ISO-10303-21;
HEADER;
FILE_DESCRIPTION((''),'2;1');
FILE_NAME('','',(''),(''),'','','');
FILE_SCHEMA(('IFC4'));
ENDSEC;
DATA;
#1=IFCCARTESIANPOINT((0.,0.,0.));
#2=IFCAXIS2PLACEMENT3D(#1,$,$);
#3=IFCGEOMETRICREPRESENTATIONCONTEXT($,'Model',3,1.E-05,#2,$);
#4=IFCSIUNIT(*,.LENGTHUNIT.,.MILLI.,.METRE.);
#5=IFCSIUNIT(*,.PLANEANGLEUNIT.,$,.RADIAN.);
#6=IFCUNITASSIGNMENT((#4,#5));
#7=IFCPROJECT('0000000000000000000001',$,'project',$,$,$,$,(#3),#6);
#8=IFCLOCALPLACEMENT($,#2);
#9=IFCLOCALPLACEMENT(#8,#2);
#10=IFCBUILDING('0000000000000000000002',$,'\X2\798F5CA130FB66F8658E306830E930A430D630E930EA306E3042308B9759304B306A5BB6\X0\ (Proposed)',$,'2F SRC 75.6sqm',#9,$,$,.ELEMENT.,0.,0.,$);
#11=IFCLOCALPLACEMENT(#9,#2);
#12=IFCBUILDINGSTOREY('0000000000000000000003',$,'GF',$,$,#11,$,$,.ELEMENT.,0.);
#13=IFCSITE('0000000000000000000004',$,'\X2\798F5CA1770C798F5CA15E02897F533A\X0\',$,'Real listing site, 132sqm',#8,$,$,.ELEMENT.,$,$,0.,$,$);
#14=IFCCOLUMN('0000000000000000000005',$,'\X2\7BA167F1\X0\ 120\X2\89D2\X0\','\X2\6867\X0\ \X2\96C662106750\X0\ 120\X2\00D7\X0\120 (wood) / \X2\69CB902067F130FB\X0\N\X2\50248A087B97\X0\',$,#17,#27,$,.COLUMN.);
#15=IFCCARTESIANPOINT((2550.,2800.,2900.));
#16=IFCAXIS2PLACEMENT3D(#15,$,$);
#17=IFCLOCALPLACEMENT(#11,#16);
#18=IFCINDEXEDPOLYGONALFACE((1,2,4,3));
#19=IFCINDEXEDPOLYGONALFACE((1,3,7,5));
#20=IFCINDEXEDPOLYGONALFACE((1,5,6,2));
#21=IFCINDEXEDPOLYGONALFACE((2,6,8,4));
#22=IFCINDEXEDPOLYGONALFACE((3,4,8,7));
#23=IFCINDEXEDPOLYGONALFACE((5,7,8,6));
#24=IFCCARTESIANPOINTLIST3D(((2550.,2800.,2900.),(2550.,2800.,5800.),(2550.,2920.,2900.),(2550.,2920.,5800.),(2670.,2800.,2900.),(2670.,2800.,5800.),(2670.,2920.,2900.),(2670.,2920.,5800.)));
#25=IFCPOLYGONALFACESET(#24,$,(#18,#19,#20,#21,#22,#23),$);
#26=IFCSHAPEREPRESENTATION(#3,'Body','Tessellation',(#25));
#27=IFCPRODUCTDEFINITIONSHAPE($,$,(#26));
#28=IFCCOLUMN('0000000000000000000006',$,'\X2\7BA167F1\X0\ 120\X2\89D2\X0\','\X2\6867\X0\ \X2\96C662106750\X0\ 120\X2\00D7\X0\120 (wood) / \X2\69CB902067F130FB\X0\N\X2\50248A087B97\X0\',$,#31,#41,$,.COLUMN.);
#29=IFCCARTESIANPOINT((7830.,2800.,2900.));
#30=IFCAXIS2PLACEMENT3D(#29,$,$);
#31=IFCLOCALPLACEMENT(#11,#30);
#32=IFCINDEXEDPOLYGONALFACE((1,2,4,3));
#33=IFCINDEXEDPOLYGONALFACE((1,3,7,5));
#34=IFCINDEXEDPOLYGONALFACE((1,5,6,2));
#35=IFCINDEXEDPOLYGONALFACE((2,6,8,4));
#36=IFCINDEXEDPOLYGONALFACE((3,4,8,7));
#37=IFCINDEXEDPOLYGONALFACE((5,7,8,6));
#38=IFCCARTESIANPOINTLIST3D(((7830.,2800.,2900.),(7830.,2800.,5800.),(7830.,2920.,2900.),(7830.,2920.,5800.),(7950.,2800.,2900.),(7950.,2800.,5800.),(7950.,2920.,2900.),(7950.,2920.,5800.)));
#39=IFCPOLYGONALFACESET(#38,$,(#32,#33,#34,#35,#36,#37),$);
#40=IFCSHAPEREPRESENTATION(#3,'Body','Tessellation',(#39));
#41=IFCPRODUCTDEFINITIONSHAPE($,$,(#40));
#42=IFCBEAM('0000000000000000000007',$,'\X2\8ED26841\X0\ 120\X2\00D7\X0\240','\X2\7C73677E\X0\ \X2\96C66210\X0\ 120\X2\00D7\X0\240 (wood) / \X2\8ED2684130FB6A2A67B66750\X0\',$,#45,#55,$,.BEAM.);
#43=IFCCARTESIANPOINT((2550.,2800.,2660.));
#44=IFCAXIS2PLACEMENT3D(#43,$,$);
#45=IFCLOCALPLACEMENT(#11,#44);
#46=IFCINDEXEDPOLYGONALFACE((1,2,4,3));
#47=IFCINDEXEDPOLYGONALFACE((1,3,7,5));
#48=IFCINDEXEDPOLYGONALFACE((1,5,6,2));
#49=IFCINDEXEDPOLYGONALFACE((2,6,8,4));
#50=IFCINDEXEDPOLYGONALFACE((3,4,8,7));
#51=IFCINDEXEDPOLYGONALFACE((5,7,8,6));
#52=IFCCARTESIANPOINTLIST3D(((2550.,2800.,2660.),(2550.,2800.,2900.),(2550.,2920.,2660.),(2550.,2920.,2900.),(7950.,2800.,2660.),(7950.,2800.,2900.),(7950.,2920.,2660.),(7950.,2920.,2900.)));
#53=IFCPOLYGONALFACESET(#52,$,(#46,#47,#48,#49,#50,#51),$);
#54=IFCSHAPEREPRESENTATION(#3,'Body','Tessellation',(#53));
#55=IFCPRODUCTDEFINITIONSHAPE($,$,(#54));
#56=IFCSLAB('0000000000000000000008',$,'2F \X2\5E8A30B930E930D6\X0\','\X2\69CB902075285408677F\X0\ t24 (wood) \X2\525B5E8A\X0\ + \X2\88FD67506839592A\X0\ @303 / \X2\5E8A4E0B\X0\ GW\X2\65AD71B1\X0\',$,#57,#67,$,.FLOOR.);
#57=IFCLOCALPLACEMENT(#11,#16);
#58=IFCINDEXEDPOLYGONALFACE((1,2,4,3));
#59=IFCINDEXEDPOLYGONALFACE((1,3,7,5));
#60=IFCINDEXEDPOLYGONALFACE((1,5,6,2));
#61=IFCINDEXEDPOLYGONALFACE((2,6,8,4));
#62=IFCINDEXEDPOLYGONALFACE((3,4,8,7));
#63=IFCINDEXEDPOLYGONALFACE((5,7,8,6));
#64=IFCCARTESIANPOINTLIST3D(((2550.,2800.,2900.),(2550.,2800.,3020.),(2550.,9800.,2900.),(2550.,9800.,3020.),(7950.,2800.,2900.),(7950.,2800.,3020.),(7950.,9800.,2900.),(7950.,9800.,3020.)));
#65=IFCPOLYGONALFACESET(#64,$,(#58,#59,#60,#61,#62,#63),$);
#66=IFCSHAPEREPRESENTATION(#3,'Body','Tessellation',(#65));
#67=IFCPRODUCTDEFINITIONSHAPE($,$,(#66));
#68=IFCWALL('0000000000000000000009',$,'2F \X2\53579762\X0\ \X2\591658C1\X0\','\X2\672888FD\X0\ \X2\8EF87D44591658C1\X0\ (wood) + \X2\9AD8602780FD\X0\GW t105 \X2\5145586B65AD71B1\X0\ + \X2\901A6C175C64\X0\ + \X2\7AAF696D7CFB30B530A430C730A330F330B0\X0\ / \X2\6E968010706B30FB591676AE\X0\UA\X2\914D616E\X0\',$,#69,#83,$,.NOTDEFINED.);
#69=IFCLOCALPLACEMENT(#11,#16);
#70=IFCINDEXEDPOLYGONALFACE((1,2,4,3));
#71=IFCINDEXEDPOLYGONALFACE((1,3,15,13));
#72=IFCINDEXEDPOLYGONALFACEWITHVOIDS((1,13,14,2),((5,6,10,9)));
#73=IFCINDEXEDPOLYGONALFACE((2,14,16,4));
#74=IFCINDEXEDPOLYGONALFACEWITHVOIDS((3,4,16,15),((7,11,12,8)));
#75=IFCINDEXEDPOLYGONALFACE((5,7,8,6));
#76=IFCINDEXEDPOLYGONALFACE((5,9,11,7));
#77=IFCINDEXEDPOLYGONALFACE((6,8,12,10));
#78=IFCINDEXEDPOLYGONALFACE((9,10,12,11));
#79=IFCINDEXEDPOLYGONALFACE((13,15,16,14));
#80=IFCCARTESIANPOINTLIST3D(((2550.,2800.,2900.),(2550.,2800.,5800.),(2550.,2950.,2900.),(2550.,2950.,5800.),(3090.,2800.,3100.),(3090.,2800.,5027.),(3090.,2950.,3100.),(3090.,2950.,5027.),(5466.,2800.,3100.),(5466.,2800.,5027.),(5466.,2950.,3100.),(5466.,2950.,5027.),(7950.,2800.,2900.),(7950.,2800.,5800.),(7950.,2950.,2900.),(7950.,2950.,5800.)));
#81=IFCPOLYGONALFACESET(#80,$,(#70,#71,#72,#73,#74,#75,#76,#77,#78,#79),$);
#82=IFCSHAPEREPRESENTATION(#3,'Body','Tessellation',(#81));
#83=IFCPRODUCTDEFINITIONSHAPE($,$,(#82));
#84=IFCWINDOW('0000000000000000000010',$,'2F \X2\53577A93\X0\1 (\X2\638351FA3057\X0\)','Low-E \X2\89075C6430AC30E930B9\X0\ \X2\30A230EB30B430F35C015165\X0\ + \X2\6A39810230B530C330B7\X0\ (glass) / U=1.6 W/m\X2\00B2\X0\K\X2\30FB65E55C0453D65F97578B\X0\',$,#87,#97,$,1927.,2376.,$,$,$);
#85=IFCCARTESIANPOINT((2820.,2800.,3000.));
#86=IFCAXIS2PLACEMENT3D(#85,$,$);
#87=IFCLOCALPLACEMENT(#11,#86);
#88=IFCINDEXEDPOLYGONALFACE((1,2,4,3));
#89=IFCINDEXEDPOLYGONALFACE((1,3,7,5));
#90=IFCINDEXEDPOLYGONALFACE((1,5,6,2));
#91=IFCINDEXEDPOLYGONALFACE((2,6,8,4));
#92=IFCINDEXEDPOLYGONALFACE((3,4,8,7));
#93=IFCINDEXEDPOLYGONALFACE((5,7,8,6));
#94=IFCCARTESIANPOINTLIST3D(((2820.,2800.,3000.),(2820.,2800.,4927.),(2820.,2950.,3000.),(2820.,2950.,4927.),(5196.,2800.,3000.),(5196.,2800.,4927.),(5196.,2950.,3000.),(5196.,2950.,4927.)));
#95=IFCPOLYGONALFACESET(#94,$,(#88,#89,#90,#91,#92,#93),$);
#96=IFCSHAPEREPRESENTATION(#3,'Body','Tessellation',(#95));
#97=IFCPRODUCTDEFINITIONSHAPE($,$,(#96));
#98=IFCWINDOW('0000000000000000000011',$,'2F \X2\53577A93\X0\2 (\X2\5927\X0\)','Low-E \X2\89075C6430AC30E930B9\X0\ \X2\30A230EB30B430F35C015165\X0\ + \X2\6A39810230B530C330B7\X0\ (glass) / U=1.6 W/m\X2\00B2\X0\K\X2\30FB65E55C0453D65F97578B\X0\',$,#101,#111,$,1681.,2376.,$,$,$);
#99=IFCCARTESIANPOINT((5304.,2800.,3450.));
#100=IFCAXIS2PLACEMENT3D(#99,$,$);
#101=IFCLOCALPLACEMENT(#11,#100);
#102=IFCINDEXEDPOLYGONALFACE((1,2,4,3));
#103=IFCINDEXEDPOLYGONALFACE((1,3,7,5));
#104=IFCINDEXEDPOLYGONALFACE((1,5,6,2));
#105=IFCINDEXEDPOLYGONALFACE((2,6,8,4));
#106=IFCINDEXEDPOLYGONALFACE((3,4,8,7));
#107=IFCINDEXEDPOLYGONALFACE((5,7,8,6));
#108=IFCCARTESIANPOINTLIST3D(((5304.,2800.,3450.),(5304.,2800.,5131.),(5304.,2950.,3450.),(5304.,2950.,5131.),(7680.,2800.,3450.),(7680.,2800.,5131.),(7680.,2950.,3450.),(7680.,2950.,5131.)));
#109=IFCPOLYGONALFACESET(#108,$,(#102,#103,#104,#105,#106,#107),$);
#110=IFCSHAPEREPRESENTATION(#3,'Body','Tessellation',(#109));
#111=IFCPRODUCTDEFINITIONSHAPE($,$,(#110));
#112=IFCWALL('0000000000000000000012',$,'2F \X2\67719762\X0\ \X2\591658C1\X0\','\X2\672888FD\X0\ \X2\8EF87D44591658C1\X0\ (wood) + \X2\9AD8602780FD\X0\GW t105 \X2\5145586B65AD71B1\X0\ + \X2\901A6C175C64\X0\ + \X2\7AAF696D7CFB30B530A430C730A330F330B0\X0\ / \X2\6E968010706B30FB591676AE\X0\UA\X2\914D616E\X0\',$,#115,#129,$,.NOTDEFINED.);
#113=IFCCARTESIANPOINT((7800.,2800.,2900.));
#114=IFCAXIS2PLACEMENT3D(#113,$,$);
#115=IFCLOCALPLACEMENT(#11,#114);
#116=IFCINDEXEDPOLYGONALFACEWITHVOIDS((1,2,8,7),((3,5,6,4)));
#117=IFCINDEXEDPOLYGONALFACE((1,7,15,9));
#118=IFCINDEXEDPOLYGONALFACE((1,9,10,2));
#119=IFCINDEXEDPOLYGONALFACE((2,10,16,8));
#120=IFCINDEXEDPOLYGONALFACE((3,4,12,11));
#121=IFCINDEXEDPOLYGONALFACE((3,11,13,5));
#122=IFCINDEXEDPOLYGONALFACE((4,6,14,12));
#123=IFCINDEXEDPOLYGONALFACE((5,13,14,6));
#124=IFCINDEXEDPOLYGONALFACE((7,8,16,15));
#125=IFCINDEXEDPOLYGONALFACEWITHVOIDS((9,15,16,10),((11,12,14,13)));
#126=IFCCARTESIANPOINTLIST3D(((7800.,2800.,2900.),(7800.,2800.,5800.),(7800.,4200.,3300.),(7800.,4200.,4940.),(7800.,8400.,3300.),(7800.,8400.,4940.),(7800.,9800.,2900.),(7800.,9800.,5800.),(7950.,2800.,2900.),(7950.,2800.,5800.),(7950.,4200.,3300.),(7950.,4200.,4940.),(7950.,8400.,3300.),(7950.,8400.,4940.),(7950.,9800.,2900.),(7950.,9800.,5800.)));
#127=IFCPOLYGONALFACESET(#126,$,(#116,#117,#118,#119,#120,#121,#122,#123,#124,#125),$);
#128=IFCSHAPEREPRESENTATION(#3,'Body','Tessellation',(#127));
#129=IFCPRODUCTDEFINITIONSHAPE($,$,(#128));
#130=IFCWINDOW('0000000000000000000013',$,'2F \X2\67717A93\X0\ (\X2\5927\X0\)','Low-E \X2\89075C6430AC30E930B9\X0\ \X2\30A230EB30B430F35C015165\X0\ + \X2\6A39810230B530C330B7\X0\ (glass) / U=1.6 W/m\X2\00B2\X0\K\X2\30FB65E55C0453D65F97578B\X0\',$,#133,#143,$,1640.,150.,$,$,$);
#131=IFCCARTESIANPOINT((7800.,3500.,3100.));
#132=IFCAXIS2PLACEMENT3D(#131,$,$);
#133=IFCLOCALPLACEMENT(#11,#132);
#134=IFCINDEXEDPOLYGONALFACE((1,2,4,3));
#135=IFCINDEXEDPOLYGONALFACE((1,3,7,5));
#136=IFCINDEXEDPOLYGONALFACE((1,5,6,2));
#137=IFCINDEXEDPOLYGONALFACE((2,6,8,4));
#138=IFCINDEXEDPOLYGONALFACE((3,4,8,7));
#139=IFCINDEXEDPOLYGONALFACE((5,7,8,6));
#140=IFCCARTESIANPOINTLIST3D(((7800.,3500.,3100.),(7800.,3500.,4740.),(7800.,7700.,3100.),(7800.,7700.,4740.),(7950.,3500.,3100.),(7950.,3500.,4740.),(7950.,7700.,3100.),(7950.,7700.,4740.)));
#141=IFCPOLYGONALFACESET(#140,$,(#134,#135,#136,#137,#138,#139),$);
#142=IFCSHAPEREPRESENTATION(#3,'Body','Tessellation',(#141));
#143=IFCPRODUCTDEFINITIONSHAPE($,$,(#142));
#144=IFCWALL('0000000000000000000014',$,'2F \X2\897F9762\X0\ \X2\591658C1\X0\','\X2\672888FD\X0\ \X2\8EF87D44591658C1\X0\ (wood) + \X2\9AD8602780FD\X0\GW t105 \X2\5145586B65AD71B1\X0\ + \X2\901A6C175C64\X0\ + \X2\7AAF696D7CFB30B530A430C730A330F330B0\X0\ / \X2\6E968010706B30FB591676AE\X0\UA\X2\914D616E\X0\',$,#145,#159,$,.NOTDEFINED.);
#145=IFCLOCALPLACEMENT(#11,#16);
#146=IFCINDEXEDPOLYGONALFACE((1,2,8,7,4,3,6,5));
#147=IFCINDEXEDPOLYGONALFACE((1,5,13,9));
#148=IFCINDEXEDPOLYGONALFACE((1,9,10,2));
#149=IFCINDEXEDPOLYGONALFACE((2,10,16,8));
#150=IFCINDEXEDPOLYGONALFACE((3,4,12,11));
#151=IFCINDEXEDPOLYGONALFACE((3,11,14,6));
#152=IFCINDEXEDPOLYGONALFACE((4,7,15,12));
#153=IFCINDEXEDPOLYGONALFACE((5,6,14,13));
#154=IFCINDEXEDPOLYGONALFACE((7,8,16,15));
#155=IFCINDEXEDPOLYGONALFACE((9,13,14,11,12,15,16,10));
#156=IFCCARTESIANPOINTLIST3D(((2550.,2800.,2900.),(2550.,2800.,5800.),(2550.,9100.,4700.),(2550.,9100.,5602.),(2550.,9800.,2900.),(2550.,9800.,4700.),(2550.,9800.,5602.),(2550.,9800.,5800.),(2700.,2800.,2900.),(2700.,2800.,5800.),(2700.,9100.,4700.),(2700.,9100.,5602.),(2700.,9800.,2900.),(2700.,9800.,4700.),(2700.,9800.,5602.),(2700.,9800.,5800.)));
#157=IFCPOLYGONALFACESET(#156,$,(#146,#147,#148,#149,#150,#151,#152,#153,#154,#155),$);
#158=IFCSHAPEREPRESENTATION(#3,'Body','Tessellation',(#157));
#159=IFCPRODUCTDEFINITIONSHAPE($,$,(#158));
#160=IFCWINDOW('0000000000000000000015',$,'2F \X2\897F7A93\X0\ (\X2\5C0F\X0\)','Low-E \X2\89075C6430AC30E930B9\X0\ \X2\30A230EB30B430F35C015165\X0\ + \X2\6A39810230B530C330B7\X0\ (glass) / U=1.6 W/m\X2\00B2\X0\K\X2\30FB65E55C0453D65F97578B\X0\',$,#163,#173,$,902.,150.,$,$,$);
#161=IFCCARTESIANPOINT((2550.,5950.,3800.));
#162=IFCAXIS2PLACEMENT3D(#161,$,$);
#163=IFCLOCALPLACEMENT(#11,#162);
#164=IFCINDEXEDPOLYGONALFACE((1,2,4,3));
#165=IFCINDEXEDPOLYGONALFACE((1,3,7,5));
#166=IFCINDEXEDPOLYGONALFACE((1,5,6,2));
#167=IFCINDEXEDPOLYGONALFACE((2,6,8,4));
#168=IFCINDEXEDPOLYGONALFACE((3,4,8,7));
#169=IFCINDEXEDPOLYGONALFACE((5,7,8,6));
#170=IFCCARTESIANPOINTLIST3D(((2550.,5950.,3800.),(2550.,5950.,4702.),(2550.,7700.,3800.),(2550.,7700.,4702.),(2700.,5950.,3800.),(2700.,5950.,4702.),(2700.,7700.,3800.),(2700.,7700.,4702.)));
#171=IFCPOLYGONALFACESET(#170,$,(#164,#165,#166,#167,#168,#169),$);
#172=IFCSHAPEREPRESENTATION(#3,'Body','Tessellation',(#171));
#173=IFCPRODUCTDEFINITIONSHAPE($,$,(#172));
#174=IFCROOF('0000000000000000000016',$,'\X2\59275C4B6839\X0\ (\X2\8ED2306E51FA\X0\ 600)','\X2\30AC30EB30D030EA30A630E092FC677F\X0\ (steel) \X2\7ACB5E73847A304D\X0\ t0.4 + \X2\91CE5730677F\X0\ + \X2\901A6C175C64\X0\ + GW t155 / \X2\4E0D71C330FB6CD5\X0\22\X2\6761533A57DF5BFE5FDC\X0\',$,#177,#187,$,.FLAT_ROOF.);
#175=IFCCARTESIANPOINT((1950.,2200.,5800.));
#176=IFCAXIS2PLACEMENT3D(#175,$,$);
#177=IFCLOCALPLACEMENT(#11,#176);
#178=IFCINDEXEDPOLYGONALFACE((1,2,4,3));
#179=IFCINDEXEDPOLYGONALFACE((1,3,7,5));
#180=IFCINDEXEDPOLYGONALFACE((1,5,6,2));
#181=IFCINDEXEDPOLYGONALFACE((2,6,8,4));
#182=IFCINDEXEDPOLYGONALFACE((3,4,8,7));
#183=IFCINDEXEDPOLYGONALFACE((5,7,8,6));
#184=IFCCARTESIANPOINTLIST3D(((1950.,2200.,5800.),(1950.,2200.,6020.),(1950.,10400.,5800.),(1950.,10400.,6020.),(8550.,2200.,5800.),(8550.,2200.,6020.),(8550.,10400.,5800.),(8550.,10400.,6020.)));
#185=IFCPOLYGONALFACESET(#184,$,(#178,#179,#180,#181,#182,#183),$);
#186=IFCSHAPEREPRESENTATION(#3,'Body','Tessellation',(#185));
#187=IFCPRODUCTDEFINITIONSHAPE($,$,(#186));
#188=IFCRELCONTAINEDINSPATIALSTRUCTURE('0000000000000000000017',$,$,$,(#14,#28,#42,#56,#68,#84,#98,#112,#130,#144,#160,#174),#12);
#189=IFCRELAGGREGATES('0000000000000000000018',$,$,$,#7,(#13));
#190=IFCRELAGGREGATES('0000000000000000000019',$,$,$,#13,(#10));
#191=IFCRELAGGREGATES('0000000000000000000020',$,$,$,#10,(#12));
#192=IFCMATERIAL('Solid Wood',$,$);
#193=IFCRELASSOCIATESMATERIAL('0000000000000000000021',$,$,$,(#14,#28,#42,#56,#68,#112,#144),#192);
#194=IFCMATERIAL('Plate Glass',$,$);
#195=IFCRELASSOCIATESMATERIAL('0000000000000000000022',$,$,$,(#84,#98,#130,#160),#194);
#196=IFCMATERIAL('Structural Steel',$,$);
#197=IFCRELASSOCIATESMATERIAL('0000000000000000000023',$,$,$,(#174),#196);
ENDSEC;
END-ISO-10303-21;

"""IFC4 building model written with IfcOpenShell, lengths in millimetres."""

from ifc_helpers import new_model, si_unit, frame, frame_2d, origin, place, context, project, spatial, rectangle, extrude, material, element, fill, save


model = new_model("IFC4")

# Units and contexts
model_context = context("Model", 3, precision=1e-05, world=origin())
ifc_project = project(units=[si_unit("LENGTHUNIT", "METRE", prefix="MILLI"), si_unit("PLANEANGLEUNIT", "RADIAN")], contexts=[model_context])

# Site, building, storey
site_placement = place(None, origin())
site = spatial("IfcSite", under=ifc_project, at=site_placement, Name="福岡県福岡市西区", ObjectType="Real listing site, 132sqm", CompositionType="ELEMENT", RefElevation=0.0)
building_placement = place(site_placement, origin())
building = spatial("IfcBuilding", under=site, at=building_placement, Name="福岡・書斎とライブラリのある静かな家 (Proposed)", ObjectType="2F SRC 75.6sqm", CompositionType="ELEMENT", ElevationOfRefHeight=0.0, ElevationOfTerrain=0.0)
storey_placement = place(building_placement, origin())
storey = spatial("IfcBuildingStorey", under=building, at=storey_placement, Name="GF", CompositionType="ELEMENT", Elevation=0.0)

# Columns
ifc_material_1 = material(Name="Solid Wood")
column_1_placement = place(storey_placement, frame((2550.0, 2800.0, 2900.0)))
element("IfcColumn", 1, at=column_1_placement, inside=storey, material=ifc_material_1, Name="管柱 120角", Description="桧 集成材 120×120 (wood) / 構造柱・N値計算", PredefinedType="COLUMN", context=model_context, shape_type="SweptSolid", body=[
    extrude(rectangle(XDim=120.0, YDim=120.0, at=frame_2d((60.0, 60.0))), frame((2550.0, 2800.0, 2900.0)), (0.0, 0.0, 1.0), 2900.0),
])
column_2_placement = place(storey_placement, frame((7830.0, 2800.0, 2900.0)))
element("IfcColumn", 2, at=column_2_placement, inside=storey, material=ifc_material_1, Name="管柱 120角", Description="桧 集成材 120×120 (wood) / 構造柱・N値計算", PredefinedType="COLUMN", context=model_context, shape_type="SweptSolid", body=[
    extrude(rectangle(XDim=120.0, YDim=120.0, at=frame_2d((60.0, 60.0))), frame((7830.0, 2800.0, 2900.0)), (0.0, 0.0, 1.0), 2900.0),
])

# Beam
beam_1_placement = place(storey_placement, frame((2550.0, 2800.0, 2660.0)))
element("IfcBeam", 3, at=beam_1_placement, inside=storey, material=ifc_material_1, Name="軒桁 120×240", Description="米松 集成 120×240 (wood) / 軒桁・横架材", PredefinedType="BEAM", context=model_context, shape_type="SweptSolid", body=[
    extrude(rectangle(XDim=5400.0, YDim=120.0, at=frame_2d((2700.0, 60.0))), frame((2550.0, 2800.0, 2660.0)), (0.0, 0.0, 1.0), 240.0),
])

# Slab
slab_placement = place(storey_placement, frame((2550.0, 2800.0, 2900.0)))
element("IfcSlab", 4, at=slab_placement, inside=storey, material=ifc_material_1, Name="2F 床スラブ", Description="構造用合板 t24 (wood) 剛床 + 製材根太 @303 / 床下 GW断熱", PredefinedType="FLOOR", context=model_context, shape_type="SweptSolid", body=[
    extrude(rectangle(XDim=5400.0, YDim=7000.0, at=frame_2d((2700.0, 3500.0))), frame((2550.0, 2800.0, 2900.0)), (0.0, 0.0, 1.0), 120.0),
])

# Wall, openings, windows
wall_1_placement = place(storey_placement, frame((2550.0, 2800.0, 2900.0)))
wall_1 = element("IfcWall", 5, at=wall_1_placement, inside=storey, material=ifc_material_1, Name="2F 南面 外壁", Description="木製 軸組外壁 (wood) + 高性能GW t105 充填断熱 + 通気層 + 窯業系サイディング / 準耐火・外皮UA配慮", PredefinedType="NOTDEFINED", context=model_context, shape_type="SweptSolid", body=[
    extrude(rectangle(XDim=5400.0, YDim=150.0, at=frame_2d((2700.0, 75.0))), frame((2550.0, 2800.0, 2900.0)), (0.0, 0.0, 1.0), 2900.0),
])
opening_1_placement = place(storey_placement, frame((2820.0, 2800.0, 3000.0)))
opening_1 = element("IfcOpeningElement", 6, at=opening_1_placement, cuts=wall_1, PredefinedType="NOTDEFINED", context=model_context, shape_type="SweptSolid", body=[
    extrude(rectangle(XDim=2376.0, YDim=150.0, at=frame_2d((1188.0, 75.0))), frame((2820.0, 2800.0, 3000.0)), (0.0, 0.0, 1.0), 1927.0),
])
opening_2_placement = place(storey_placement, frame((5304.0, 2800.0, 3450.0)))
opening_2 = element("IfcOpeningElement", 7, at=opening_2_placement, cuts=wall_1, PredefinedType="NOTDEFINED", context=model_context, shape_type="SweptSolid", body=[
    extrude(rectangle(XDim=2376.0, YDim=150.0, at=frame_2d((1188.0, 75.0))), frame((5304.0, 2800.0, 3450.0)), (0.0, 0.0, 1.0), 1681.0),
])
ifc_material_2 = material(Name="Plate Glass")
window_1_placement = place(storey_placement, frame((2820.0, 2800.0, 3000.0)))
window_1 = element("IfcWindow", 8, at=window_1_placement, inside=storey, material=ifc_material_2, Name="2F 南窓1 (掃出し)", Description="Low-E 複層ガラス アルゴン封入 + 樹脂サッシ (glass) / U=1.6 W/m²K・日射取得型", OverallHeight=1927.0, OverallWidth=2376.0, context=model_context, shape_type="SweptSolid", body=[
    extrude(rectangle(XDim=2376.0, YDim=150.0, at=frame_2d((1188.0, 75.0))), frame((2820.0, 2800.0, 3000.0)), (0.0, 0.0, 1.0), 1927.0),
])
fill(opening_1, window_1)
window_2_placement = place(storey_placement, frame((5304.0, 2800.0, 3450.0)))
window_2 = element("IfcWindow", 9, at=window_2_placement, inside=storey, material=ifc_material_2, Name="2F 南窓2 (大)", Description="Low-E 複層ガラス アルゴン封入 + 樹脂サッシ (glass) / U=1.6 W/m²K・日射取得型", OverallHeight=1681.0, OverallWidth=2376.0, context=model_context, shape_type="SweptSolid", body=[
    extrude(rectangle(XDim=2376.0, YDim=150.0, at=frame_2d((1188.0, 75.0))), frame((5304.0, 2800.0, 3450.0)), (0.0, 0.0, 1.0), 1681.0),
])
fill(opening_2, window_2)

# Walls, openings, windows
wall_2_placement = place(storey_placement, frame((7800.0, 2800.0, 2900.0)))
wall_2 = element("IfcWall", 10, at=wall_2_placement, inside=storey, material=ifc_material_1, Name="2F 東面 外壁", Description="木製 軸組外壁 (wood) + 高性能GW t105 充填断熱 + 通気層 + 窯業系サイディング / 準耐火・外皮UA配慮", PredefinedType="NOTDEFINED", context=model_context, shape_type="SweptSolid", body=[
    extrude(rectangle(XDim=150.0, YDim=7000.0, at=frame_2d((75.0, 3500.0))), frame((7800.0, 2800.0, 2900.0)), (0.0, 0.0, 1.0), 2900.0),
])
opening_3_placement = place(storey_placement, frame((7800.0, 3500.0, 3100.0)))
opening_3 = element("IfcOpeningElement", 11, at=opening_3_placement, cuts=wall_2, PredefinedType="NOTDEFINED", context=model_context, shape_type="SweptSolid", body=[
    extrude(rectangle(XDim=150.0, YDim=4200.0, at=frame_2d((75.0, 2100.0))), frame((7800.0, 3500.0, 3100.0)), (0.0, 0.0, 1.0), 1640.0),
])
window_3_placement = place(storey_placement, frame((7800.0, 3500.0, 3100.0)))
window_3 = element("IfcWindow", 12, at=window_3_placement, inside=storey, material=ifc_material_2, Name="2F 東窓 (大)", Description="Low-E 複層ガラス アルゴン封入 + 樹脂サッシ (glass) / U=1.6 W/m²K・日射取得型", OverallHeight=1640.0, OverallWidth=150.0, context=model_context, shape_type="SweptSolid", body=[
    extrude(rectangle(XDim=150.0, YDim=4200.0, at=frame_2d((75.0, 2100.0))), frame((7800.0, 3500.0, 3100.0)), (0.0, 0.0, 1.0), 1640.0),
])
fill(opening_3, window_3)
wall_3_placement = place(storey_placement, frame((2550.0, 2800.0, 2900.0)))
wall_3 = element("IfcWall", 13, at=wall_3_placement, inside=storey, material=ifc_material_1, Name="2F 西面 外壁", Description="木製 軸組外壁 (wood) + 高性能GW t105 充填断熱 + 通気層 + 窯業系サイディング / 準耐火・外皮UA配慮", PredefinedType="NOTDEFINED", context=model_context, shape_type="SweptSolid", body=[
    extrude(rectangle(XDim=150.0, YDim=7000.0, at=frame_2d((75.0, 3500.0))), frame((2550.0, 2800.0, 2900.0)), (0.0, 0.0, 1.0), 2900.0),
])
opening_4_placement = place(storey_placement, frame((2550.0, 5950.0, 3800.0)))
opening_4 = element("IfcOpeningElement", 14, at=opening_4_placement, cuts=wall_3, PredefinedType="NOTDEFINED", context=model_context, shape_type="SweptSolid", body=[
    extrude(rectangle(XDim=150.0, YDim=1750.0, at=frame_2d((75.0, 875.0))), frame((2550.0, 5950.0, 3800.0)), (0.0, 0.0, 1.0), 902.0),
])
window_4_placement = place(storey_placement, frame((2550.0, 5950.0, 3800.0)))
window_4 = element("IfcWindow", 15, at=window_4_placement, inside=storey, material=ifc_material_2, Name="2F 西窓 (小)", Description="Low-E 複層ガラス アルゴン封入 + 樹脂サッシ (glass) / U=1.6 W/m²K・日射取得型", OverallHeight=902.0, OverallWidth=150.0, context=model_context, shape_type="SweptSolid", body=[
    extrude(rectangle(XDim=150.0, YDim=1750.0, at=frame_2d((75.0, 875.0))), frame((2550.0, 5950.0, 3800.0)), (0.0, 0.0, 1.0), 902.0),
])
fill(opening_4, window_4)

# Roof
ifc_material_3 = material(Name="Structural Steel")
roof_placement = place(storey_placement, frame((1950.0, 2200.0, 5800.0)))
element("IfcRoof", 16, at=roof_placement, inside=storey, material=ifc_material_3, Name="大屋根 (軒の出 600)", Description="ガルバリウム鋼板 (steel) 立平葺き t0.4 + 野地板 + 通気層 + GW t155 / 不燃・法22条区域対応", PredefinedType="FLAT_ROOF", context=model_context, shape_type="SweptSolid", body=[
    extrude(rectangle(XDim=6600.0, YDim=8200.0, at=frame_2d((3300.0, 4100.0))), frame((1950.0, 2200.0, 5800.0)), (0.0, 0.0, 1.0), 220.0),
])

save(model, "model.ifc")
